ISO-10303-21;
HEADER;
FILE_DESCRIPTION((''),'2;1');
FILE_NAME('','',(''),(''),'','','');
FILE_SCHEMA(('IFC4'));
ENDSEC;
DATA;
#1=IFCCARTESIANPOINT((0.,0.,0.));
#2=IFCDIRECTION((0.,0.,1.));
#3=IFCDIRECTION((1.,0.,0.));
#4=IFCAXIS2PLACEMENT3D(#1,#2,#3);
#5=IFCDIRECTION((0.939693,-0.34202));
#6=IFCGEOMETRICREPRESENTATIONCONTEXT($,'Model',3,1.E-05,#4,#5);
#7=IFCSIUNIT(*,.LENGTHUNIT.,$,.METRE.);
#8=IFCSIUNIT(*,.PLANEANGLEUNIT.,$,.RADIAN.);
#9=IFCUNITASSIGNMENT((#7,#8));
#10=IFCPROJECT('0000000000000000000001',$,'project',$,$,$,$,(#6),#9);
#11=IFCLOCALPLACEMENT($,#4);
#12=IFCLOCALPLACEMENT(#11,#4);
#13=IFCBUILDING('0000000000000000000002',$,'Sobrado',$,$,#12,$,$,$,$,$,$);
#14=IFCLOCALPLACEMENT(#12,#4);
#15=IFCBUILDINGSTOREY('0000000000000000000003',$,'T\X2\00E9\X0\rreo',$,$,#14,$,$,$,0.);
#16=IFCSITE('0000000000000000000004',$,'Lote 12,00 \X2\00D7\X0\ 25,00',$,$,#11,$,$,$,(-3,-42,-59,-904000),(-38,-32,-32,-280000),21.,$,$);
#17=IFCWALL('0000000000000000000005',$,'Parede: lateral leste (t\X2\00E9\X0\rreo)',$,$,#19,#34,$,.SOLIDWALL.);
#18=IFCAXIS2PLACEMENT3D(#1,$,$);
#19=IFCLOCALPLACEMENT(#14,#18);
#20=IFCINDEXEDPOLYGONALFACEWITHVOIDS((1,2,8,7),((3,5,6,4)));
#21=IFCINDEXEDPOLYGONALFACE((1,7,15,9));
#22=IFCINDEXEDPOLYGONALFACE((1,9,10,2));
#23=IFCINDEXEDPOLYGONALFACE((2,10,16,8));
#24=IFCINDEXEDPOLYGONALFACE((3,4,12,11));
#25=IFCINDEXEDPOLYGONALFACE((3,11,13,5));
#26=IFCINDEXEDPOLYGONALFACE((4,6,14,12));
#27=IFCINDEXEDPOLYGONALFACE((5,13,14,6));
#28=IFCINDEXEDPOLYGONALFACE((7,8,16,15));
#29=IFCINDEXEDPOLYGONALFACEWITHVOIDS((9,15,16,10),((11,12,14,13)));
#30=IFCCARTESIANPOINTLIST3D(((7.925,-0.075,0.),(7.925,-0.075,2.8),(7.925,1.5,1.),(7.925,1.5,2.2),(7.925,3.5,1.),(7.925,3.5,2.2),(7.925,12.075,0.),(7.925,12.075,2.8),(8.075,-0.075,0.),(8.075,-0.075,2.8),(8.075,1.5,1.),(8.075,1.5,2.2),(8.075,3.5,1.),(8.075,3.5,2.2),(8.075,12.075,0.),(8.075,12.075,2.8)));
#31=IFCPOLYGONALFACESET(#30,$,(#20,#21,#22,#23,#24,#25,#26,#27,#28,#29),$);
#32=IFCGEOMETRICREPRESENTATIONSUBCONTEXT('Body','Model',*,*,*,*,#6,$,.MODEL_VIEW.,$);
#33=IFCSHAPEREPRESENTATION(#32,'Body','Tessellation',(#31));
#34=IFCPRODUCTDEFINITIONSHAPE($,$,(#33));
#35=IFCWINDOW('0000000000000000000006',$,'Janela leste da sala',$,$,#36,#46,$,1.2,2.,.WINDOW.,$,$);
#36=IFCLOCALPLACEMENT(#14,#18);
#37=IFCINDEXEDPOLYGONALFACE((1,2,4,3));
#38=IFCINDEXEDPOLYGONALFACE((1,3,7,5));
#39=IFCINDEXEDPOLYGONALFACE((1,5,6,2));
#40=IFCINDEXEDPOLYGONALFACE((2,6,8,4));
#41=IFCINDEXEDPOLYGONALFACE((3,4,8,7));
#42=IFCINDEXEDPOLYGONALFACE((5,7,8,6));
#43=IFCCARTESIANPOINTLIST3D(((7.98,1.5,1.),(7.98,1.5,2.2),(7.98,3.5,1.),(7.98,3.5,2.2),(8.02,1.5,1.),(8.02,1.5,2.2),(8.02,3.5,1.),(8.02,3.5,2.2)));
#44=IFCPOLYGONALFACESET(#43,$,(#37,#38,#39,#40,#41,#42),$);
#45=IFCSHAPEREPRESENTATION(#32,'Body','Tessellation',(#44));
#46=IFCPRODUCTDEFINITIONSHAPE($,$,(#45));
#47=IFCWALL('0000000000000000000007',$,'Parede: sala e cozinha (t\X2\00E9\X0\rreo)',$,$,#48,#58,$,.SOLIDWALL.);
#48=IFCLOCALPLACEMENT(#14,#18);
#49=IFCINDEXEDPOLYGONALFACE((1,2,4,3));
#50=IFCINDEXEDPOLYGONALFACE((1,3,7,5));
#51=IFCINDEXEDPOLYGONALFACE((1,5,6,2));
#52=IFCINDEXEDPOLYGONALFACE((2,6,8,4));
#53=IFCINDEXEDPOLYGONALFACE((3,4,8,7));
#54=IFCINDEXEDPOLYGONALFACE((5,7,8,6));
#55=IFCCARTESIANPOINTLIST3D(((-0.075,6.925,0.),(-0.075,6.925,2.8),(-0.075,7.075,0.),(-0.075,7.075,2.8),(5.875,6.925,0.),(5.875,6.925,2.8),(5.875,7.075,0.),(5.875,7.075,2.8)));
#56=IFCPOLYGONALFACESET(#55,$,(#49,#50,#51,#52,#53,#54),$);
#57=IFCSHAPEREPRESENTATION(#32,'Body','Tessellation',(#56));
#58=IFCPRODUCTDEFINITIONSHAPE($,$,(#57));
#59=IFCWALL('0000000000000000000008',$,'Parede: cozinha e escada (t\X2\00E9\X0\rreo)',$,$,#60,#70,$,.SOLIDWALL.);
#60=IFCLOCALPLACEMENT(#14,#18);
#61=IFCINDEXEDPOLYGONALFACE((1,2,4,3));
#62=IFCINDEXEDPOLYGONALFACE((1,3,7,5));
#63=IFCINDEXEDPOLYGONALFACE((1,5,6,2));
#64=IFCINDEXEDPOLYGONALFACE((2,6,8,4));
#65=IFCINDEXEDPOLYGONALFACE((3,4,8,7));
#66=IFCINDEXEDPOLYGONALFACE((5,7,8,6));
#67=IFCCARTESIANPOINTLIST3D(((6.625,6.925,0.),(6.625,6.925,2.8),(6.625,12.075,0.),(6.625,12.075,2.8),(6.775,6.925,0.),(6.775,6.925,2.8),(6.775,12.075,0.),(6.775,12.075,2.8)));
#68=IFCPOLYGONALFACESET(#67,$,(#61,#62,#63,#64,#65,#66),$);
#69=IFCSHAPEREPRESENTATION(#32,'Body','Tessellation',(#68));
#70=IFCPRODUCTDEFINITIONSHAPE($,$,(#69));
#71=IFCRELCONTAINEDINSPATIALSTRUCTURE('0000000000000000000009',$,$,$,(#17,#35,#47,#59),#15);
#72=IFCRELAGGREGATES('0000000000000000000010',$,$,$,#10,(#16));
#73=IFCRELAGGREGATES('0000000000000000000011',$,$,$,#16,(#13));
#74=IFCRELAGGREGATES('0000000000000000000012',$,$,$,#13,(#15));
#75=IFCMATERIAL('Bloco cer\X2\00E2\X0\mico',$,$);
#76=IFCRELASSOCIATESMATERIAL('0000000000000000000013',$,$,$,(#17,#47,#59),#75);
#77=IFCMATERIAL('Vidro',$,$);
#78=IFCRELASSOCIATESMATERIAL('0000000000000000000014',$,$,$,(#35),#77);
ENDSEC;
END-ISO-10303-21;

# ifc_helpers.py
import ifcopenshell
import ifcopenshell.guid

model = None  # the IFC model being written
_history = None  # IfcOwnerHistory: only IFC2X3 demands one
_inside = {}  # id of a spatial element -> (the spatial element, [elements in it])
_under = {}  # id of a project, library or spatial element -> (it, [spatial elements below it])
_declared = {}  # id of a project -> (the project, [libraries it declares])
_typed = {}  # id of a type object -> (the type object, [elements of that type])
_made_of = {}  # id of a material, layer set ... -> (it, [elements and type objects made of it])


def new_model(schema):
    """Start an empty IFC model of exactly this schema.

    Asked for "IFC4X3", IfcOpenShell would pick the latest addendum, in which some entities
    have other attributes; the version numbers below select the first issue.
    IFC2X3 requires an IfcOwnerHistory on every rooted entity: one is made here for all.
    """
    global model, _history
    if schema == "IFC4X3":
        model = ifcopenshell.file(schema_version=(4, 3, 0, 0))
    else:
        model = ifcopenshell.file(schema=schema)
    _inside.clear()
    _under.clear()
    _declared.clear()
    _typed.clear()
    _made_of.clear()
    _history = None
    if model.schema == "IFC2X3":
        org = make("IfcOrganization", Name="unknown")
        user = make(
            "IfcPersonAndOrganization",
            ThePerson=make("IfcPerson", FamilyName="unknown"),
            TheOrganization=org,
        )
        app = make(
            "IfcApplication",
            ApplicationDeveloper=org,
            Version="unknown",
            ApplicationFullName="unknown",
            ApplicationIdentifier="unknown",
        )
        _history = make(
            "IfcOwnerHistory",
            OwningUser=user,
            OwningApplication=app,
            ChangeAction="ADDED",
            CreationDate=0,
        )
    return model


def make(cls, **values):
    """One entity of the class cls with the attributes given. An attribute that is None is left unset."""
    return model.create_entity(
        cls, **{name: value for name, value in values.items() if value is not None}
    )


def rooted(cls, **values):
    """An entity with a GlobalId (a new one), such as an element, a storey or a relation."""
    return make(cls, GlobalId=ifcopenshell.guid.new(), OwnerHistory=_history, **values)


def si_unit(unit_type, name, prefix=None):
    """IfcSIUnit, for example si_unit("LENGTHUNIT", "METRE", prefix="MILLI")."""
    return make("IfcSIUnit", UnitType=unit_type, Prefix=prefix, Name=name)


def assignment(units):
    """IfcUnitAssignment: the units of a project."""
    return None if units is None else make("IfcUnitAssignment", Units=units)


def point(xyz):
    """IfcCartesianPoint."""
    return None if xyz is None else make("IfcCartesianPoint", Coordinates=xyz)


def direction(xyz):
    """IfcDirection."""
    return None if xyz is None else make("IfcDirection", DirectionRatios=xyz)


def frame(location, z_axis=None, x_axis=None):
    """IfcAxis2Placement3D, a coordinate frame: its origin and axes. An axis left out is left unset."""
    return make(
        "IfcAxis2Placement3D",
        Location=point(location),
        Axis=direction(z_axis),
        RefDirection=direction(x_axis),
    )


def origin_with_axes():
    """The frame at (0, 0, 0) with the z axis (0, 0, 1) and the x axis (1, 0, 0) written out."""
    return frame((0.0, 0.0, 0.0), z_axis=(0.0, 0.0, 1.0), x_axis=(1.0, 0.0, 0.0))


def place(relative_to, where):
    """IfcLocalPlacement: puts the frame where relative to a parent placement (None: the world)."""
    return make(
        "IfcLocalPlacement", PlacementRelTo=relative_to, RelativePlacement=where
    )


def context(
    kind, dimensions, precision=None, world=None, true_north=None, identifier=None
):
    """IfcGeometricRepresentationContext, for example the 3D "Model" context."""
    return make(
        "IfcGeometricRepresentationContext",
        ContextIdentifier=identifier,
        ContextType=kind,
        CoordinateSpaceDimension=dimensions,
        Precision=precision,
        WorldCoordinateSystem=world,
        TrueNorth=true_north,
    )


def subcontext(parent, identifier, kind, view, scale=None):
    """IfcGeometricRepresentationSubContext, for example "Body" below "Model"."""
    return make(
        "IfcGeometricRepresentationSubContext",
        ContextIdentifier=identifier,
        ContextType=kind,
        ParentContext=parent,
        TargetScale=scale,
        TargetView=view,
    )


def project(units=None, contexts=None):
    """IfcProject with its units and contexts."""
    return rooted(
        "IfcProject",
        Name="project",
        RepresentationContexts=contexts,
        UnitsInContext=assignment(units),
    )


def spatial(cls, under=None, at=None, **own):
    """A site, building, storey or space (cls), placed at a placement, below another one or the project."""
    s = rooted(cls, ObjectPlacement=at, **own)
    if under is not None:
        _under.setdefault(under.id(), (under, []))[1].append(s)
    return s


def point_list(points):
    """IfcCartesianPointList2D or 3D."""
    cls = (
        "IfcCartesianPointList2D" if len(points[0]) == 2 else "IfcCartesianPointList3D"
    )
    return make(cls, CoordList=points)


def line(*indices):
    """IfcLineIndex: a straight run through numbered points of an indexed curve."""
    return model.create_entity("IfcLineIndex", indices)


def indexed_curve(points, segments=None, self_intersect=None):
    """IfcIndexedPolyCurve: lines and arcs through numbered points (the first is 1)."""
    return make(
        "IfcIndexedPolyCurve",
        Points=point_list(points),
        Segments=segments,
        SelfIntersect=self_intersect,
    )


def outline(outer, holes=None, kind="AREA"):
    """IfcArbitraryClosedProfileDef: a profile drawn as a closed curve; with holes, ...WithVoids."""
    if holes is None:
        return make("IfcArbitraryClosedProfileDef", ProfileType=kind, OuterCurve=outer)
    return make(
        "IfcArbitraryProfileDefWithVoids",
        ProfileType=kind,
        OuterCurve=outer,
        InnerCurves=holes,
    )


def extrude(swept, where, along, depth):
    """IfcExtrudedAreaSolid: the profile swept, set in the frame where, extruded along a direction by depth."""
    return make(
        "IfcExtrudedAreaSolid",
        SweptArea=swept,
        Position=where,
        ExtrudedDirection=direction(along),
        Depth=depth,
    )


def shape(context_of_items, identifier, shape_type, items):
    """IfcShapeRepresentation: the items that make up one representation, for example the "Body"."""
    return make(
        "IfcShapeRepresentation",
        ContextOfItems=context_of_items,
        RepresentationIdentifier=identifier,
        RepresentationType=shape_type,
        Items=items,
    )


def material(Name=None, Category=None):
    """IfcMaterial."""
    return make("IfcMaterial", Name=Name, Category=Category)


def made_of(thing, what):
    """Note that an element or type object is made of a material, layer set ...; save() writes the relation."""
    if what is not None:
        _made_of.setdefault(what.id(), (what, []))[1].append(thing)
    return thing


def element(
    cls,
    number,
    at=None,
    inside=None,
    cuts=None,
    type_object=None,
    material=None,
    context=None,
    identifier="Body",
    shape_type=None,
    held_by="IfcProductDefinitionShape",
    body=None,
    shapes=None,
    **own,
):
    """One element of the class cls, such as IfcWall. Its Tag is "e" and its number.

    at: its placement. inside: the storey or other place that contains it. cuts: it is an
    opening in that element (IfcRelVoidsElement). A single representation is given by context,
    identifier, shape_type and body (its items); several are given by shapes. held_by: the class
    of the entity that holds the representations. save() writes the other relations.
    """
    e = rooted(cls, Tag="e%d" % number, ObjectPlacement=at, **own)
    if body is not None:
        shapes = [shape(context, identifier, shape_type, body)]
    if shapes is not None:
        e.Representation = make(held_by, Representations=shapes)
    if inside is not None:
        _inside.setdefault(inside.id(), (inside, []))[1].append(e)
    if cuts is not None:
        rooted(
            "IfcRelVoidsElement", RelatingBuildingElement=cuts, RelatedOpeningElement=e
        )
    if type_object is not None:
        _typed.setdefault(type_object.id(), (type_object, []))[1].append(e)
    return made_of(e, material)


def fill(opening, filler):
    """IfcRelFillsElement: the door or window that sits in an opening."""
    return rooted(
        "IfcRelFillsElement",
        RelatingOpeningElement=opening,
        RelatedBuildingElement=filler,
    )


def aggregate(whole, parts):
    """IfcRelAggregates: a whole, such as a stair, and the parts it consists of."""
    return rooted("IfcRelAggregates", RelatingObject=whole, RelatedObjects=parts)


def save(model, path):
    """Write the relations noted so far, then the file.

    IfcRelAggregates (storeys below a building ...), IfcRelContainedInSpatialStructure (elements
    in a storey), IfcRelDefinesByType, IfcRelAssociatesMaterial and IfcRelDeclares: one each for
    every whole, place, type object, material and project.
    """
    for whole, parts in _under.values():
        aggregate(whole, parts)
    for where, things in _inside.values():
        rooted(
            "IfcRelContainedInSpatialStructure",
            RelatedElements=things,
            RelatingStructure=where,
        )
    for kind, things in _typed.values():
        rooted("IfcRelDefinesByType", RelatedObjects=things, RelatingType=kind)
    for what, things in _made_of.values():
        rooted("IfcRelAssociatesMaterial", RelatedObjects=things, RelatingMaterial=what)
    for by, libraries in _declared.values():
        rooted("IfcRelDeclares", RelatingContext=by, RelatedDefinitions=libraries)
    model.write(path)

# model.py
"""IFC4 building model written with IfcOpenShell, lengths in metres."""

from ifc_helpers import new_model, si_unit, direction, frame, origin_with_axes, place, context, subcontext, project, spatial, line, indexed_curve, outline, extrude, material, element, fill, save


model = new_model("IFC4")

# Units and contexts
model_context = context("Model", 3, precision=1e-05, world=origin_with_axes(), true_north=direction((0.939693, -0.34202)))
body_context = subcontext(model_context, "Body", "Model", "MODEL_VIEW")
ifc_project = project(units=[si_unit("LENGTHUNIT", "METRE"), si_unit("PLANEANGLEUNIT", "RADIAN")], contexts=[model_context])

# Site, building, storey
site_placement = place(None, origin_with_axes())
site = spatial("IfcSite", under=ifc_project, at=site_placement, Name="Lote 12,00 × 25,00", RefLatitude=(-3, -42, -59, -904000), RefLongitude=(-38, -32, -32, -280000), RefElevation=21.0)
building_placement = place(site_placement, origin_with_axes())
building = spatial("IfcBuilding", under=site, at=building_placement, Name="Sobrado")
storey_placement = place(building_placement, origin_with_axes())
storey = spatial("IfcBuildingStorey", under=building, at=storey_placement, Name="Térreo", Elevation=0.0)

# Shared definitions
ifc_material_1 = material(Name="Concreto armado")

# Shared definitions
ifc_material_2 = material(Name="Bloco cerâmico")
ifc_material_3 = material(Name="Vidro")

# Wall, opening, window
wall_1_placement = place(storey_placement, origin_with_axes())
wall_1 = element("IfcWall", 1, at=wall_1_placement, inside=storey, material=ifc_material_2, Name="Parede: lateral leste (térreo)", PredefinedType="SOLIDWALL", context=body_context, shape_type="SweptSolid", body=[
    extrude(outline(indexed_curve([(7.925, -0.075), (8.075, -0.075), (8.075, 12.075), (7.925, 12.075)], segments=[line(1, 2, 3, 4, 1)])), origin_with_axes(), (0.0, 0.0, 1.0), 2.8),
])
opening_1_placement = place(wall_1_placement, origin_with_axes())
opening_1 = element("IfcOpeningElement", 2, at=opening_1_placement, cuts=wall_1, material=ifc_material_1, PredefinedType="OPENING", context=body_context, shape_type="SweptSolid", body=[
    extrude(outline(indexed_curve([(7.875, 1.5), (8.125, 1.5), (8.125, 3.5), (7.875, 3.5)], segments=[line(1, 2, 3, 4, 1)])), frame((0.0, 0.0, 1.0), z_axis=(0.0, 0.0, 1.0), x_axis=(1.0, 0.0, 0.0)), (0.0, 0.0, 1.0), 1.2),
])
window_1_placement = place(storey_placement, origin_with_axes())
window_1 = element("IfcWindow", 3, at=window_1_placement, inside=storey, material=ifc_material_3, Name="Janela leste da sala", OverallHeight=1.2, OverallWidth=2.0, PredefinedType="WINDOW", context=body_context, shape_type="SweptSolid", body=[
    extrude(outline(indexed_curve([(7.98, 1.5), (8.02, 1.5), (8.02, 3.5), (7.98, 3.5)], segments=[line(1, 2, 3, 4, 1)])), frame((0.0, 0.0, 1.0), z_axis=(0.0, 0.0, 1.0), x_axis=(1.0, 0.0, 0.0)), (0.0, 0.0, 1.0), 1.2),
])
fill(opening_1, window_1)

# Walls
wall_2_placement = place(storey_placement, origin_with_axes())
element("IfcWall", 4, at=wall_2_placement, inside=storey, material=ifc_material_2, Name="Parede: sala e cozinha (térreo)", PredefinedType="SOLIDWALL", context=body_context, shape_type="SweptSolid", body=[
    extrude(outline(indexed_curve([(-0.075, 6.925), (5.875, 6.925), (5.875, 7.075), (-0.075, 7.075)], segments=[line(1, 2, 3, 4, 1)])), origin_with_axes(), (0.0, 0.0, 1.0), 2.8),
])
wall_3_placement = place(storey_placement, origin_with_axes())
element("IfcWall", 5, at=wall_3_placement, inside=storey, material=ifc_material_2, Name="Parede: cozinha e escada (térreo)", PredefinedType="SOLIDWALL", context=body_context, shape_type="SweptSolid", body=[
    extrude(outline(indexed_curve([(6.625, 6.925), (6.775, 6.925), (6.775, 12.075), (6.625, 12.075)], segments=[line(1, 2, 3, 4, 1)])), origin_with_axes(), (0.0, 0.0, 1.0), 2.8),
])

save(model, "model.ifc")
